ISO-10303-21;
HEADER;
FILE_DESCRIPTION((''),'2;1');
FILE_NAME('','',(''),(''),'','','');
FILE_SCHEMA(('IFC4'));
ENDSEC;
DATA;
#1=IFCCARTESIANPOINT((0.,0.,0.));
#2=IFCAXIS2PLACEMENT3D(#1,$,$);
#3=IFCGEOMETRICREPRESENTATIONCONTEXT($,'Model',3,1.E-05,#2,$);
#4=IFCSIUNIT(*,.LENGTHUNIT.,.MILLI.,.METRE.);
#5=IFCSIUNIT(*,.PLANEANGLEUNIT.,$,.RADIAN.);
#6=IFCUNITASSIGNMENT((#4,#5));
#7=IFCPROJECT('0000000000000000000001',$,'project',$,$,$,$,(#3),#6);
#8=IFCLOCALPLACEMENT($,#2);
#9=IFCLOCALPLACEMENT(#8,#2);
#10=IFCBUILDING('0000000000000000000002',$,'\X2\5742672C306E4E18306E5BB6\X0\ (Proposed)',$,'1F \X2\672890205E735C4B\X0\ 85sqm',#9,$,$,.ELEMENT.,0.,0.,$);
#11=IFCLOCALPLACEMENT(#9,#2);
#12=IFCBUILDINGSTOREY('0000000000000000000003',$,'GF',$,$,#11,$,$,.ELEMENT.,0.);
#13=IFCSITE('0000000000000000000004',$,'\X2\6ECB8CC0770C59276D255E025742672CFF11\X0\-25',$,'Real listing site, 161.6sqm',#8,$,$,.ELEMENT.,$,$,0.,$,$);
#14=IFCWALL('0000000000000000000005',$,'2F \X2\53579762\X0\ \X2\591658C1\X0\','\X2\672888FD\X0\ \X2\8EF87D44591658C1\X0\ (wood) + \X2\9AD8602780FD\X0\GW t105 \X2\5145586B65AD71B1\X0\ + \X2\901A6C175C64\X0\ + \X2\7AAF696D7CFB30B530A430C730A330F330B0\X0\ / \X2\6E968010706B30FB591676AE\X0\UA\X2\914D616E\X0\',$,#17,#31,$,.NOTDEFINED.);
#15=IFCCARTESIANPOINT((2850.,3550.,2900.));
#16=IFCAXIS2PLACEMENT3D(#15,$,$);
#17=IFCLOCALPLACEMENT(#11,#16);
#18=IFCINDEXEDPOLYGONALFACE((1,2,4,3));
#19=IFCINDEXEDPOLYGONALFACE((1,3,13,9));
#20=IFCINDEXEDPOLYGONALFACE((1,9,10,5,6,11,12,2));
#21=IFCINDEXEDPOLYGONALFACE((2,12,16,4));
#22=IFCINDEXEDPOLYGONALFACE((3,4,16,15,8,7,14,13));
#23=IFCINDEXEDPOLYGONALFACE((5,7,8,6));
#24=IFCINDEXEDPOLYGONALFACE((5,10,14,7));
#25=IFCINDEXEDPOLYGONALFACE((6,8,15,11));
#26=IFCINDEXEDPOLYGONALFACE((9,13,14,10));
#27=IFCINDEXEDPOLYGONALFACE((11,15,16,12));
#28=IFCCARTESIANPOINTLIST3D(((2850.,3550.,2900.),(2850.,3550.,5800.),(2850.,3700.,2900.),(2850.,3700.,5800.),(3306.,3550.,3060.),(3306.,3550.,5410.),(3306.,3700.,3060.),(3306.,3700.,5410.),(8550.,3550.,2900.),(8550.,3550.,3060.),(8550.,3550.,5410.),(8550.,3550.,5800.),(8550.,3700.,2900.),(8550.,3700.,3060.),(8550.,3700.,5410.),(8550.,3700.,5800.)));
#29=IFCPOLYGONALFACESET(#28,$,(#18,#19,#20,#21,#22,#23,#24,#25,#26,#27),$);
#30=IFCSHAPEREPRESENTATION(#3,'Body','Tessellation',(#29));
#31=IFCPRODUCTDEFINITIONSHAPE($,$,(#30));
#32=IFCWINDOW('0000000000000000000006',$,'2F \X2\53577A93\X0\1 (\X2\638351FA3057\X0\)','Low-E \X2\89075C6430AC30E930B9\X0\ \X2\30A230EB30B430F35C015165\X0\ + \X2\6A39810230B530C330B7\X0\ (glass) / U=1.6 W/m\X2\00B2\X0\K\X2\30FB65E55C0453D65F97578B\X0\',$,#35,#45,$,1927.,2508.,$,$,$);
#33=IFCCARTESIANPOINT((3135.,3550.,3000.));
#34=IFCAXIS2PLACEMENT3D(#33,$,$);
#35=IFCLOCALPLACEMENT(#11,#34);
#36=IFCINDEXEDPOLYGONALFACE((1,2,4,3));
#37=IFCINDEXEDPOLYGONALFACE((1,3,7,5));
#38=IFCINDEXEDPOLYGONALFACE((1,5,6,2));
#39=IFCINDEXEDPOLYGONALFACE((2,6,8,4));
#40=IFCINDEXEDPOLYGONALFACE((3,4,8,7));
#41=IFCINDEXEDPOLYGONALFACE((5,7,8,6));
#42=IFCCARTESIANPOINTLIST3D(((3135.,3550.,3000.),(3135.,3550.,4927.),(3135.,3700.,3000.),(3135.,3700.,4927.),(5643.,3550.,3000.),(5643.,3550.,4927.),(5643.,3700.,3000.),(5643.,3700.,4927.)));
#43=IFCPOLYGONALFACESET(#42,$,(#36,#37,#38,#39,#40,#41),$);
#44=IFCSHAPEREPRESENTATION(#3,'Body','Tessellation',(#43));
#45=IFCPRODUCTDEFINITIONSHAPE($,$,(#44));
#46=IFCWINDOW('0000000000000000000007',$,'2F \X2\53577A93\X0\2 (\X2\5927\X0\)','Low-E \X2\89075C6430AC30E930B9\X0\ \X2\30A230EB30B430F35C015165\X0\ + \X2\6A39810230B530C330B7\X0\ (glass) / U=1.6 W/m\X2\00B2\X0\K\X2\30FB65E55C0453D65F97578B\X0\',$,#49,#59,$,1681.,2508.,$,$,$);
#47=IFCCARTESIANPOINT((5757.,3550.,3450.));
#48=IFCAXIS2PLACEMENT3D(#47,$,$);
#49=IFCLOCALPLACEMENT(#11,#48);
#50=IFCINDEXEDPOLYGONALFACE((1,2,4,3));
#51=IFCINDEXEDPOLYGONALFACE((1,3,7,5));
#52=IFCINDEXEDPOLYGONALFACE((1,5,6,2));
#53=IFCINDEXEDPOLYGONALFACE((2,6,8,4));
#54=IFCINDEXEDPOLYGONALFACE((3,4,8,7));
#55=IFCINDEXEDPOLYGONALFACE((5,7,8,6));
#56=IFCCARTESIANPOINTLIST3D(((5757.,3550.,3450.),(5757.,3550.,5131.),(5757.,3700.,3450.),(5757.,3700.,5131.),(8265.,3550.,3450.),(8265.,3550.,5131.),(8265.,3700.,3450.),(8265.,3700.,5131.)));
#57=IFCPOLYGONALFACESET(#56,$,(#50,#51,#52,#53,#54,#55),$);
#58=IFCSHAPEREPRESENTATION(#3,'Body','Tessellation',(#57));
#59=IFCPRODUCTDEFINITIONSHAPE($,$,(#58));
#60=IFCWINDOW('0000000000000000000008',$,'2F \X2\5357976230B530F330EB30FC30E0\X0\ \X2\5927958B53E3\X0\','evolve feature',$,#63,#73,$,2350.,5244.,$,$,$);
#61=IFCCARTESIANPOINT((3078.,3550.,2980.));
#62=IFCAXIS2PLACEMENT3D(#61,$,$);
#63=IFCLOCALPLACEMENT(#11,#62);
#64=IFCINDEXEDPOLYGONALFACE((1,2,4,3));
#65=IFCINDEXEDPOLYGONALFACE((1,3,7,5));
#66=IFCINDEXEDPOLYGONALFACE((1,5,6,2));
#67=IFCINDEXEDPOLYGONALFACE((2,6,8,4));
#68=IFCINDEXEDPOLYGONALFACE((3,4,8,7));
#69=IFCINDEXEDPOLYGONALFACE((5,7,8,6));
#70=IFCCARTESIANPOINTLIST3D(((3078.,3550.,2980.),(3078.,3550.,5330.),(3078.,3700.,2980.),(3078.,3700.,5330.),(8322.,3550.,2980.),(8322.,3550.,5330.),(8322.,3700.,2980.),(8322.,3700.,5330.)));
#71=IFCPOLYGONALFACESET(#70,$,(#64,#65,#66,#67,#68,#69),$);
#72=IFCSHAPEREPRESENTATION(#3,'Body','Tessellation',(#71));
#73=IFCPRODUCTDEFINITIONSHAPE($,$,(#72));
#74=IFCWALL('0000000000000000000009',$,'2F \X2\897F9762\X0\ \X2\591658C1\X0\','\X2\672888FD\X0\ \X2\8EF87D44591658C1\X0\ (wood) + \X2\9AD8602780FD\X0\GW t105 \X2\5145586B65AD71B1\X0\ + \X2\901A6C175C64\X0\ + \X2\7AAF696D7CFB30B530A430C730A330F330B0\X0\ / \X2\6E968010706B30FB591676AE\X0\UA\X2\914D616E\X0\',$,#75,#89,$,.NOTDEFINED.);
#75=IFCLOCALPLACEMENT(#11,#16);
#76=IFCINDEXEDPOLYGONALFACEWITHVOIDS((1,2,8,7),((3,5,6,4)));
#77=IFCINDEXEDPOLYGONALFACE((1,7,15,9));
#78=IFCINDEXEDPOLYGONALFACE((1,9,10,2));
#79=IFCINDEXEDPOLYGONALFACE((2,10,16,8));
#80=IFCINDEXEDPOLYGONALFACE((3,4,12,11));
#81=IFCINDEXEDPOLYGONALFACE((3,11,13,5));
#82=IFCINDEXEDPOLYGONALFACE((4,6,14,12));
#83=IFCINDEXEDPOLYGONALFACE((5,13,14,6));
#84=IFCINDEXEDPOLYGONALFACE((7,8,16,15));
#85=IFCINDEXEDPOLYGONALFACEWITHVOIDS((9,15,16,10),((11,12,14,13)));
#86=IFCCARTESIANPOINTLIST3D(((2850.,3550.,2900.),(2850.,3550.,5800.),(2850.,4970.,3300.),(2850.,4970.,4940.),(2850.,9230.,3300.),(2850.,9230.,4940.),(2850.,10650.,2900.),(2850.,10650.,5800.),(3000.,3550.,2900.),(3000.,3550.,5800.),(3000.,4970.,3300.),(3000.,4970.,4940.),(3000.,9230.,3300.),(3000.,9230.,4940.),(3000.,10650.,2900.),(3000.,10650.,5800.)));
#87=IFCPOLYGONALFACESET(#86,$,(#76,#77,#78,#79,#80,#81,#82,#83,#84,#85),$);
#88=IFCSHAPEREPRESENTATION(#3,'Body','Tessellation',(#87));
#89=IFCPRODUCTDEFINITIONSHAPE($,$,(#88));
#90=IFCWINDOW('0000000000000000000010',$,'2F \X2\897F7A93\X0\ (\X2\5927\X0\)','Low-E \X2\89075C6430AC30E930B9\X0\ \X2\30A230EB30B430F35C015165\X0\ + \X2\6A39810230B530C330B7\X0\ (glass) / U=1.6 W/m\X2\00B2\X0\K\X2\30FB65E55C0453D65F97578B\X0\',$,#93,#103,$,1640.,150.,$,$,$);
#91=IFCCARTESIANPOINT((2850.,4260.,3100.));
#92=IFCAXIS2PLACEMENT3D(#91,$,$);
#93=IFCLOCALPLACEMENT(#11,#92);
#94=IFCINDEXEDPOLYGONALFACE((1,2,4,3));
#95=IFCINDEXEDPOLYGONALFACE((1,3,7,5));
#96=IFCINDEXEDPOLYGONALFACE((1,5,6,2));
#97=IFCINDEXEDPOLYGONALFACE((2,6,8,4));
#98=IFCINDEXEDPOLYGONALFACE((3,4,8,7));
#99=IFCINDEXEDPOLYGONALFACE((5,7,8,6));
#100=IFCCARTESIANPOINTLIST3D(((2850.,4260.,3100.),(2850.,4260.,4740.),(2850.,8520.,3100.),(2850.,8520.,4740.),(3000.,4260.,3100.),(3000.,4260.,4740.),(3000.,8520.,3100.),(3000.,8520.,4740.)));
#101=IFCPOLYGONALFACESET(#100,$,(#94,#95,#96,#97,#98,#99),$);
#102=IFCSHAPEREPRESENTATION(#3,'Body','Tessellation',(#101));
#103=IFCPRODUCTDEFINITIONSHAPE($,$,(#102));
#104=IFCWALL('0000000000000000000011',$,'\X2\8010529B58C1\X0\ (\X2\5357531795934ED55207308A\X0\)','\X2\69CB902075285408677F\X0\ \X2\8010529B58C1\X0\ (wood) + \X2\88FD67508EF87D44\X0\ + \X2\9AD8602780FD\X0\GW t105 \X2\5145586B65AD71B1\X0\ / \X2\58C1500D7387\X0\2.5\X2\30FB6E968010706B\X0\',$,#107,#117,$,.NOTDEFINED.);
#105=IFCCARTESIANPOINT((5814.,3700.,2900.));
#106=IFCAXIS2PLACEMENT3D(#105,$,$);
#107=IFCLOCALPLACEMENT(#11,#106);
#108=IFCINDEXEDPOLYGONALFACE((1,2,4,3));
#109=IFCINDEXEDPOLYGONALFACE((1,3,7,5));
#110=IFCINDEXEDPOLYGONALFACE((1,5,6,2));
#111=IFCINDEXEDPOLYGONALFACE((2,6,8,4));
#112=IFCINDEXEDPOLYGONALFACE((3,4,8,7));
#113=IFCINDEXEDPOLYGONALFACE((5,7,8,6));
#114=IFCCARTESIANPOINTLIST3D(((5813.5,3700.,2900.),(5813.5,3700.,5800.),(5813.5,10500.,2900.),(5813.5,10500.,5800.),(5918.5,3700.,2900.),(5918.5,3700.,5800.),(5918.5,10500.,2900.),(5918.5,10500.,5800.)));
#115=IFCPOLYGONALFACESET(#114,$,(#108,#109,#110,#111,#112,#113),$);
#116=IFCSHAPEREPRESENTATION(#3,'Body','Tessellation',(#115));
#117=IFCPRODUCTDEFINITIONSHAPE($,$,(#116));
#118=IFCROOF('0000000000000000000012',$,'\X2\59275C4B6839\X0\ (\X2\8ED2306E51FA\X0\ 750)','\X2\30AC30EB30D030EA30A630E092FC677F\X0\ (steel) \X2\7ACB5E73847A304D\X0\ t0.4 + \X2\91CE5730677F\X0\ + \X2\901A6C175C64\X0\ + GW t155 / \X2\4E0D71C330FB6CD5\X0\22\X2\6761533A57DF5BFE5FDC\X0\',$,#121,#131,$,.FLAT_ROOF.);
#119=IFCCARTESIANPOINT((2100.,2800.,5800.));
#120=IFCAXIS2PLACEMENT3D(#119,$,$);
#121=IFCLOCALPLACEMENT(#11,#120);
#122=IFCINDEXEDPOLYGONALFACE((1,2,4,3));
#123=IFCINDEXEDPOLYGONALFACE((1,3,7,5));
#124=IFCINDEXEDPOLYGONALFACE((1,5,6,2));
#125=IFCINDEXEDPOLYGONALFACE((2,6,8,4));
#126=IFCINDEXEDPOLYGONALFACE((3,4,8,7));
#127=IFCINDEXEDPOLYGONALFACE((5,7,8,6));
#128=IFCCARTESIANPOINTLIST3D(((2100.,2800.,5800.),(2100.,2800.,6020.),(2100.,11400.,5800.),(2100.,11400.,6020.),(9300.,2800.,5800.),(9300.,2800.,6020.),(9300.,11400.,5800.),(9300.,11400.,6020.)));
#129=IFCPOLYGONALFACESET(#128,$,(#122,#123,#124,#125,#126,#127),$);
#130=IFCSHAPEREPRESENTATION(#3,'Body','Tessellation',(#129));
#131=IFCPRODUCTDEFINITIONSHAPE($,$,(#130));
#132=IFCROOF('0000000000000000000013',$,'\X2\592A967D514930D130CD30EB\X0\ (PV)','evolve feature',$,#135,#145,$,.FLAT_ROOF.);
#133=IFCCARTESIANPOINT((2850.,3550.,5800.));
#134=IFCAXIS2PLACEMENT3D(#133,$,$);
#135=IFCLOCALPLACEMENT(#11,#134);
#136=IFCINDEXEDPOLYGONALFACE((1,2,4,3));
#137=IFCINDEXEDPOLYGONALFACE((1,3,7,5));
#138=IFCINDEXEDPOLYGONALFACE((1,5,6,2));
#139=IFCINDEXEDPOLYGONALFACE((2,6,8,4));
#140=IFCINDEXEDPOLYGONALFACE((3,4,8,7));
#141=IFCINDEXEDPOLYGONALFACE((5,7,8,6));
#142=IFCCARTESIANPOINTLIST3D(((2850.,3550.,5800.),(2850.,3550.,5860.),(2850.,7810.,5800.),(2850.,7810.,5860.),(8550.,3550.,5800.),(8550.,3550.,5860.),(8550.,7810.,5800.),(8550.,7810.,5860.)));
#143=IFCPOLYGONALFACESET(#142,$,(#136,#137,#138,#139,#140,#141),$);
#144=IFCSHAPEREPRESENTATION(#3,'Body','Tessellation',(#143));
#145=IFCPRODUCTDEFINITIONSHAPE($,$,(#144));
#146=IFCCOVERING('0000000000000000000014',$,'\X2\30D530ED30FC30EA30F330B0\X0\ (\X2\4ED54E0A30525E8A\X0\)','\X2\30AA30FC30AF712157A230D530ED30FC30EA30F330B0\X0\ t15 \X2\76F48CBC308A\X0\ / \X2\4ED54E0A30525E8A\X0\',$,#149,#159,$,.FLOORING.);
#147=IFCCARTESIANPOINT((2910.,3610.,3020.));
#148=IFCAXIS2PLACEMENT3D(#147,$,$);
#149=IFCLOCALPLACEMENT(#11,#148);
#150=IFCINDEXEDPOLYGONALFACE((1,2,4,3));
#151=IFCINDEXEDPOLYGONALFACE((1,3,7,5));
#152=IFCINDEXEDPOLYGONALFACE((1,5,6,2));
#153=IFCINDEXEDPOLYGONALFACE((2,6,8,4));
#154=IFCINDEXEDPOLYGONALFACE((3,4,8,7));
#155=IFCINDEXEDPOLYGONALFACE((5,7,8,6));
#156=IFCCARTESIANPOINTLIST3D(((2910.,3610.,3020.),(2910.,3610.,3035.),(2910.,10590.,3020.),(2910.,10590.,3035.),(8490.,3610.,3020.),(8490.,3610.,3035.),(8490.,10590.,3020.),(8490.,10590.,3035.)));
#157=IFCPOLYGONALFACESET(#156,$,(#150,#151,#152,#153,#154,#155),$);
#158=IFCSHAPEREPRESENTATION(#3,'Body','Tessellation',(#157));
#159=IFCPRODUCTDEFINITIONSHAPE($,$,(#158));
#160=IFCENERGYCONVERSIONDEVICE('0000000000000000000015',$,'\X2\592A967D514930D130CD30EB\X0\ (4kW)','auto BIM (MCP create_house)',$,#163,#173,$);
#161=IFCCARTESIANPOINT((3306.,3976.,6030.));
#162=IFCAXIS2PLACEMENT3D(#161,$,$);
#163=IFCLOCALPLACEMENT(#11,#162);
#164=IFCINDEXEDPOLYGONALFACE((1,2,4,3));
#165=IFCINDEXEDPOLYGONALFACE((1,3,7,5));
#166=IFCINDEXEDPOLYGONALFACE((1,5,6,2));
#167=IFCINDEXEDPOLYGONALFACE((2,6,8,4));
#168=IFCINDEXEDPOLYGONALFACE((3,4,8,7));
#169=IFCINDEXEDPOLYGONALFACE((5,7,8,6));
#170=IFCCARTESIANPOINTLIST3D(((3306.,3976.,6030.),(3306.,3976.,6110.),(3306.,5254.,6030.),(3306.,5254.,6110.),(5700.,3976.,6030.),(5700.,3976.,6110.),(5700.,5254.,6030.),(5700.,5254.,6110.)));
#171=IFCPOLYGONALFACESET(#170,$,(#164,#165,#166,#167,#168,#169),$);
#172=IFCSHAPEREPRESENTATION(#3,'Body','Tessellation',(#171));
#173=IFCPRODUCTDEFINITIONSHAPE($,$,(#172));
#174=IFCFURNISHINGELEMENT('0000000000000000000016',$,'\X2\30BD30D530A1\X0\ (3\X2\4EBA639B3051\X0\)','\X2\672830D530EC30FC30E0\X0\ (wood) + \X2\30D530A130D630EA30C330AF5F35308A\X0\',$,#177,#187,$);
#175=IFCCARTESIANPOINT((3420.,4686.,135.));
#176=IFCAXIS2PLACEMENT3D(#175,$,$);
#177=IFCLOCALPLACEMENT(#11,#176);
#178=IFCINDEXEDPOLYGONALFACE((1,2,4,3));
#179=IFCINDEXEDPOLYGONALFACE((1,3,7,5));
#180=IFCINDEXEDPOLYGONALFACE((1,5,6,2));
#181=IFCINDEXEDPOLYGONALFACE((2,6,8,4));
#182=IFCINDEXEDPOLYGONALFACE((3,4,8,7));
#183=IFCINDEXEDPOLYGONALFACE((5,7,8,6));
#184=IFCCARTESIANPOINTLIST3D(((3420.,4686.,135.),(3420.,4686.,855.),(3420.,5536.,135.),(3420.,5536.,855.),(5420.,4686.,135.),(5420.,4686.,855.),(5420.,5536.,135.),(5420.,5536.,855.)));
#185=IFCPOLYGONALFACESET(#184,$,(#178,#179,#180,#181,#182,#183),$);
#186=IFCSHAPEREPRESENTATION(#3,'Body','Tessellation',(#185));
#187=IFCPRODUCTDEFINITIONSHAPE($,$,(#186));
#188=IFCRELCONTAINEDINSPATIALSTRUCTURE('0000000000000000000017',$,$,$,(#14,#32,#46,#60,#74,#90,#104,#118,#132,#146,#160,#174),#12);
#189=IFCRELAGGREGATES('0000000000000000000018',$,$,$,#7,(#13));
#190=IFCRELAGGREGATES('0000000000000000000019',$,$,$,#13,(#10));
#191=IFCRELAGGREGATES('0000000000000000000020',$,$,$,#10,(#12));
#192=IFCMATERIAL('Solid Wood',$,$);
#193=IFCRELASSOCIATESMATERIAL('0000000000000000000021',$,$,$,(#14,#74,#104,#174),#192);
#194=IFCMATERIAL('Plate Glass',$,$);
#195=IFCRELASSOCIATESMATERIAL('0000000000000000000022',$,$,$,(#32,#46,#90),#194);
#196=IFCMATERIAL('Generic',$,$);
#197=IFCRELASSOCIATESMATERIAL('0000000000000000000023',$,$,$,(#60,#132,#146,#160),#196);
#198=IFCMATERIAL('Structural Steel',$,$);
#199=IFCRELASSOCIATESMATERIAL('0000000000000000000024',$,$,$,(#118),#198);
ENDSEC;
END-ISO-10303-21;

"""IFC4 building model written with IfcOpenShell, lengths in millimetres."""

from ifc_helpers import new_model, si_unit, frame, frame_2d, origin, place, context, project, spatial, rectangle, extrude, material, element, fill, save


model = new_model("IFC4")

# Units and contexts
model_context = context("Model", 3, precision=1e-05, world=origin())
ifc_project = project(units=[si_unit("LENGTHUNIT", "METRE", prefix="MILLI"), si_unit("PLANEANGLEUNIT", "RADIAN")], contexts=[model_context])

# Site, building, storey
site_placement = place(None, origin())
site = spatial("IfcSite", under=ifc_project, at=site_placement, Name="滋賀県大津市坂本１-25", ObjectType="Real listing site, 161.6sqm", CompositionType="ELEMENT", RefElevation=0.0)
building_placement = place(site_placement, origin())
building = spatial("IfcBuilding", under=site, at=building_placement, Name="坂本の丘の家 (Proposed)", ObjectType="1F 木造平屋 85sqm", CompositionType="ELEMENT", ElevationOfRefHeight=0.0, ElevationOfTerrain=0.0)
storey_placement = place(building_placement, origin())
storey = spatial("IfcBuildingStorey", under=building, at=storey_placement, Name="GF", CompositionType="ELEMENT", Elevation=0.0)

# Shared definitions
ifc_material_1 = material(Name="Solid Wood")

# Wall, openings, windows
wall_1_placement = place(storey_placement, frame((2850.0, 3550.0, 2900.0)))
wall_1 = element("IfcWall", 1, at=wall_1_placement, inside=storey, material=ifc_material_1, Name="2F 南面 外壁", Description="木製 軸組外壁 (wood) + 高性能GW t105 充填断熱 + 通気層 + 窯業系サイディング / 準耐火・外皮UA配慮", PredefinedType="NOTDEFINED", context=model_context, shape_type="SweptSolid", body=[
    extrude(rectangle(XDim=5700.0, YDim=150.0, at=frame_2d((2850.0, 75.0))), frame((2850.0, 3550.0, 2900.0)), (0.0, 0.0, 1.0), 2900.0),
])
opening_1_placement = place(storey_placement, frame((3135.0, 3550.0, 3000.0)))
opening_1 = element("IfcOpeningElement", 2, at=opening_1_placement, cuts=wall_1, PredefinedType="NOTDEFINED", context=model_context, shape_type="SweptSolid", body=[
    extrude(rectangle(XDim=2508.0, YDim=150.0, at=frame_2d((1254.0, 75.0))), frame((3135.0, 3550.0, 3000.0)), (0.0, 0.0, 1.0), 1927.0),
])
opening_2_placement = place(storey_placement, frame((5757.0, 3550.0, 3450.0)))
opening_2 = element("IfcOpeningElement", 3, at=opening_2_placement, cuts=wall_1, PredefinedType="NOTDEFINED", context=model_context, shape_type="SweptSolid", body=[
    extrude(rectangle(XDim=2508.0, YDim=150.0, at=frame_2d((1254.0, 75.0))), frame((5757.0, 3550.0, 3450.0)), (0.0, 0.0, 1.0), 1681.0),
])
opening_3_placement = place(storey_placement, frame((3078.0, 3550.0, 2980.0)))
opening_3 = element("IfcOpeningElement", 4, at=opening_3_placement, cuts=wall_1, PredefinedType="NOTDEFINED", context=model_context, shape_type="SweptSolid", body=[
    extrude(rectangle(XDim=5244.0, YDim=150.0, at=frame_2d((2622.0, 75.0))), frame((3078.0, 3550.0, 2980.0)), (0.0, 0.0, 1.0), 2350.0),
])
ifc_material_2 = material(Name="Plate Glass")
window_1_placement = place(storey_placement, frame((3135.0, 3550.0, 3000.0)))
window_1 = element("IfcWindow", 5, at=window_1_placement, inside=storey, material=ifc_material_2, Name="2F 南窓1 (掃出し)", Description="Low-E 複層ガラス アルゴン封入 + 樹脂サッシ (glass) / U=1.6 W/m²K・日射取得型", OverallHeight=1927.0, OverallWidth=2508.0, context=model_context, shape_type="SweptSolid", body=[
    extrude(rectangle(XDim=2508.0, YDim=150.0, at=frame_2d((1254.0, 75.0))), frame((3135.0, 3550.0, 3000.0)), (0.0, 0.0, 1.0), 1927.0),
])
fill(opening_1, window_1)
window_2_placement = place(storey_placement, frame((5757.0, 3550.0, 3450.0)))
window_2 = element("IfcWindow", 6, at=window_2_placement, inside=storey, material=ifc_material_2, Name="2F 南窓2 (大)", Description="Low-E 複層ガラス アルゴン封入 + 樹脂サッシ (glass) / U=1.6 W/m²K・日射取得型", OverallHeight=1681.0, OverallWidth=2508.0, context=model_context, shape_type="SweptSolid", body=[
    extrude(rectangle(XDim=2508.0, YDim=150.0, at=frame_2d((1254.0, 75.0))), frame((5757.0, 3550.0, 3450.0)), (0.0, 0.0, 1.0), 1681.0),
])
fill(opening_2, window_2)
ifc_material_3 = material(Name="Generic")
window_3_placement = place(storey_placement, frame((3078.0, 3550.0, 2980.0)))
window_3 = element("IfcWindow", 7, at=window_3_placement, inside=storey, material=ifc_material_3, Name="2F 南面サンルーム 大開口", Description="evolve feature", OverallHeight=2350.0, OverallWidth=5244.0, context=model_context, shape_type="SweptSolid", body=[
    extrude(rectangle(XDim=5244.0, YDim=150.0, at=frame_2d((2622.0, 75.0))), frame((3078.0, 3550.0, 2980.0)), (0.0, 0.0, 1.0), 2350.0),
])
fill(opening_3, window_3)

# Wall, opening, window
wall_2_placement = place(storey_placement, frame((2850.0, 3550.0, 2900.0)))
wall_2 = element("IfcWall", 8, at=wall_2_placement, inside=storey, material=ifc_material_1, Name="2F 西面 外壁", Description="木製 軸組外壁 (wood) + 高性能GW t105 充填断熱 + 通気層 + 窯業系サイディング / 準耐火・外皮UA配慮", PredefinedType="NOTDEFINED", context=model_context, shape_type="SweptSolid", body=[
    extrude(rectangle(XDim=150.0, YDim=7100.0, at=frame_2d((75.0, 3550.0))), frame((2850.0, 3550.0, 2900.0)), (0.0, 0.0, 1.0), 2900.0),
])
opening_4_placement = place(storey_placement, frame((2850.0, 4260.0, 3100.0)))
opening_4 = element("IfcOpeningElement", 9, at=opening_4_placement, cuts=wall_2, PredefinedType="NOTDEFINED", context=model_context, shape_type="SweptSolid", body=[
    extrude(rectangle(XDim=150.0, YDim=4260.0, at=frame_2d((75.0, 2130.0))), frame((2850.0, 4260.0, 3100.0)), (0.0, 0.0, 1.0), 1640.0),
])
window_4_placement = place(storey_placement, frame((2850.0, 4260.0, 3100.0)))
window_4 = element("IfcWindow", 10, at=window_4_placement, inside=storey, material=ifc_material_2, Name="2F 西窓 (大)", Description="Low-E 複層ガラス アルゴン封入 + 樹脂サッシ (glass) / U=1.6 W/m²K・日射取得型", OverallHeight=1640.0, OverallWidth=150.0, context=model_context, shape_type="SweptSolid", body=[
    extrude(rectangle(XDim=150.0, YDim=4260.0, at=frame_2d((75.0, 2130.0))), frame((2850.0, 4260.0, 3100.0)), (0.0, 0.0, 1.0), 1640.0),
])
fill(opening_4, window_4)

# Wall
wall_3_placement = place(storey_placement, frame((5814.0, 3700.0, 2900.0)))
element("IfcWall", 11, at=wall_3_placement, inside=storey, material=ifc_material_1, Name="耐力壁 (南北間仕切り)", Description="構造用合板 耐力壁 (wood) + 製材軸組 + 高性能GW t105 充填断熱 / 壁倍率2.5・準耐火", PredefinedType="NOTDEFINED", context=model_context, shape_type="SweptSolid", body=[
    extrude(rectangle(XDim=105.0, YDim=6800.0, at=frame_2d((52.0, 3400.0))), frame((5814.0, 3700.0, 2900.0)), (0.0, 0.0, 1.0), 2900.0),
])

# Roofs
ifc_material_4 = material(Name="Structural Steel")
roof_1_placement = place(storey_placement, frame((2100.0, 2800.0, 5800.0)))
element("IfcRoof", 12, at=roof_1_placement, inside=storey, material=ifc_material_4, Name="大屋根 (軒の出 750)", Description="ガルバリウム鋼板 (steel) 立平葺き t0.4 + 野地板 + 通気層 + GW t155 / 不燃・法22条区域対応", PredefinedType="FLAT_ROOF", context=model_context, shape_type="SweptSolid", body=[
    extrude(rectangle(XDim=7200.0, YDim=8600.0, at=frame_2d((3600.0, 4300.0))), frame((2100.0, 2800.0, 5800.0)), (0.0, 0.0, 1.0), 220.0),
])
roof_2_placement = place(storey_placement, frame((2850.0, 3550.0, 5800.0)))
element("IfcRoof", 13, at=roof_2_placement, inside=storey, material=ifc_material_3, Name="太陽光パネル (PV)", Description="evolve feature", PredefinedType="FLAT_ROOF", context=model_context, shape_type="SweptSolid", body=[
    extrude(rectangle(XDim=5700.0, YDim=4260.0, at=frame_2d((2850.0, 2130.0))), frame((2850.0, 3550.0, 5800.0)), (0.0, 0.0, 1.0), 60.0),
])

# Covering
covering_placement = place(storey_placement, frame((2910.0, 3610.0, 3020.0)))
element("IfcCovering", 14, at=covering_placement, inside=storey, material=ifc_material_3, Name="フローリング (仕上げ床)", Description="オーク無垢フローリング t15 直貼り / 仕上げ床", PredefinedType="FLOORING", context=model_context, shape_type="SweptSolid", body=[
    extrude(rectangle(XDim=5580.0, YDim=6980.0, at=frame_2d((2790.0, 3490.0))), frame((2910.0, 3610.0, 3020.0)), (0.0, 0.0, 1.0), 15.0),
])

# Energy conversion device
energy_conversion_device_placement = place(storey_placement, frame((3306.0, 3976.0, 6030.0)))
element("IfcEnergyConversionDevice", 15, at=energy_conversion_device_placement, inside=storey, material=ifc_material_3, Name="太陽光パネル (4kW)", Description="auto BIM (MCP create_house)", context=model_context, shape_type="SweptSolid", body=[
    extrude(rectangle(XDim=2394.0, YDim=1278.0, at=frame_2d((1197.0, 639.0))), frame((3306.0, 3976.0, 6030.0)), (0.0, 0.0, 1.0), 80.0),
])

# Furnishing element
furnishing_1_placement = place(storey_placement, frame((3420.0, 4686.0, 135.0)))
element("IfcFurnishingElement", 16, at=furnishing_1_placement, inside=storey, material=ifc_material_1, Name="ソファ (3人掛け)", Description="木フレーム (wood) + ファブリック張り", context=model_context, shape_type="SweptSolid", body=[
    extrude(rectangle(XDim=2000.0, YDim=850.0, at=frame_2d((1000.0, 425.0))), frame((3420.0, 4686.0, 135.0)), (0.0, 0.0, 1.0), 720.0),
])

save(model, "model.ifc")
